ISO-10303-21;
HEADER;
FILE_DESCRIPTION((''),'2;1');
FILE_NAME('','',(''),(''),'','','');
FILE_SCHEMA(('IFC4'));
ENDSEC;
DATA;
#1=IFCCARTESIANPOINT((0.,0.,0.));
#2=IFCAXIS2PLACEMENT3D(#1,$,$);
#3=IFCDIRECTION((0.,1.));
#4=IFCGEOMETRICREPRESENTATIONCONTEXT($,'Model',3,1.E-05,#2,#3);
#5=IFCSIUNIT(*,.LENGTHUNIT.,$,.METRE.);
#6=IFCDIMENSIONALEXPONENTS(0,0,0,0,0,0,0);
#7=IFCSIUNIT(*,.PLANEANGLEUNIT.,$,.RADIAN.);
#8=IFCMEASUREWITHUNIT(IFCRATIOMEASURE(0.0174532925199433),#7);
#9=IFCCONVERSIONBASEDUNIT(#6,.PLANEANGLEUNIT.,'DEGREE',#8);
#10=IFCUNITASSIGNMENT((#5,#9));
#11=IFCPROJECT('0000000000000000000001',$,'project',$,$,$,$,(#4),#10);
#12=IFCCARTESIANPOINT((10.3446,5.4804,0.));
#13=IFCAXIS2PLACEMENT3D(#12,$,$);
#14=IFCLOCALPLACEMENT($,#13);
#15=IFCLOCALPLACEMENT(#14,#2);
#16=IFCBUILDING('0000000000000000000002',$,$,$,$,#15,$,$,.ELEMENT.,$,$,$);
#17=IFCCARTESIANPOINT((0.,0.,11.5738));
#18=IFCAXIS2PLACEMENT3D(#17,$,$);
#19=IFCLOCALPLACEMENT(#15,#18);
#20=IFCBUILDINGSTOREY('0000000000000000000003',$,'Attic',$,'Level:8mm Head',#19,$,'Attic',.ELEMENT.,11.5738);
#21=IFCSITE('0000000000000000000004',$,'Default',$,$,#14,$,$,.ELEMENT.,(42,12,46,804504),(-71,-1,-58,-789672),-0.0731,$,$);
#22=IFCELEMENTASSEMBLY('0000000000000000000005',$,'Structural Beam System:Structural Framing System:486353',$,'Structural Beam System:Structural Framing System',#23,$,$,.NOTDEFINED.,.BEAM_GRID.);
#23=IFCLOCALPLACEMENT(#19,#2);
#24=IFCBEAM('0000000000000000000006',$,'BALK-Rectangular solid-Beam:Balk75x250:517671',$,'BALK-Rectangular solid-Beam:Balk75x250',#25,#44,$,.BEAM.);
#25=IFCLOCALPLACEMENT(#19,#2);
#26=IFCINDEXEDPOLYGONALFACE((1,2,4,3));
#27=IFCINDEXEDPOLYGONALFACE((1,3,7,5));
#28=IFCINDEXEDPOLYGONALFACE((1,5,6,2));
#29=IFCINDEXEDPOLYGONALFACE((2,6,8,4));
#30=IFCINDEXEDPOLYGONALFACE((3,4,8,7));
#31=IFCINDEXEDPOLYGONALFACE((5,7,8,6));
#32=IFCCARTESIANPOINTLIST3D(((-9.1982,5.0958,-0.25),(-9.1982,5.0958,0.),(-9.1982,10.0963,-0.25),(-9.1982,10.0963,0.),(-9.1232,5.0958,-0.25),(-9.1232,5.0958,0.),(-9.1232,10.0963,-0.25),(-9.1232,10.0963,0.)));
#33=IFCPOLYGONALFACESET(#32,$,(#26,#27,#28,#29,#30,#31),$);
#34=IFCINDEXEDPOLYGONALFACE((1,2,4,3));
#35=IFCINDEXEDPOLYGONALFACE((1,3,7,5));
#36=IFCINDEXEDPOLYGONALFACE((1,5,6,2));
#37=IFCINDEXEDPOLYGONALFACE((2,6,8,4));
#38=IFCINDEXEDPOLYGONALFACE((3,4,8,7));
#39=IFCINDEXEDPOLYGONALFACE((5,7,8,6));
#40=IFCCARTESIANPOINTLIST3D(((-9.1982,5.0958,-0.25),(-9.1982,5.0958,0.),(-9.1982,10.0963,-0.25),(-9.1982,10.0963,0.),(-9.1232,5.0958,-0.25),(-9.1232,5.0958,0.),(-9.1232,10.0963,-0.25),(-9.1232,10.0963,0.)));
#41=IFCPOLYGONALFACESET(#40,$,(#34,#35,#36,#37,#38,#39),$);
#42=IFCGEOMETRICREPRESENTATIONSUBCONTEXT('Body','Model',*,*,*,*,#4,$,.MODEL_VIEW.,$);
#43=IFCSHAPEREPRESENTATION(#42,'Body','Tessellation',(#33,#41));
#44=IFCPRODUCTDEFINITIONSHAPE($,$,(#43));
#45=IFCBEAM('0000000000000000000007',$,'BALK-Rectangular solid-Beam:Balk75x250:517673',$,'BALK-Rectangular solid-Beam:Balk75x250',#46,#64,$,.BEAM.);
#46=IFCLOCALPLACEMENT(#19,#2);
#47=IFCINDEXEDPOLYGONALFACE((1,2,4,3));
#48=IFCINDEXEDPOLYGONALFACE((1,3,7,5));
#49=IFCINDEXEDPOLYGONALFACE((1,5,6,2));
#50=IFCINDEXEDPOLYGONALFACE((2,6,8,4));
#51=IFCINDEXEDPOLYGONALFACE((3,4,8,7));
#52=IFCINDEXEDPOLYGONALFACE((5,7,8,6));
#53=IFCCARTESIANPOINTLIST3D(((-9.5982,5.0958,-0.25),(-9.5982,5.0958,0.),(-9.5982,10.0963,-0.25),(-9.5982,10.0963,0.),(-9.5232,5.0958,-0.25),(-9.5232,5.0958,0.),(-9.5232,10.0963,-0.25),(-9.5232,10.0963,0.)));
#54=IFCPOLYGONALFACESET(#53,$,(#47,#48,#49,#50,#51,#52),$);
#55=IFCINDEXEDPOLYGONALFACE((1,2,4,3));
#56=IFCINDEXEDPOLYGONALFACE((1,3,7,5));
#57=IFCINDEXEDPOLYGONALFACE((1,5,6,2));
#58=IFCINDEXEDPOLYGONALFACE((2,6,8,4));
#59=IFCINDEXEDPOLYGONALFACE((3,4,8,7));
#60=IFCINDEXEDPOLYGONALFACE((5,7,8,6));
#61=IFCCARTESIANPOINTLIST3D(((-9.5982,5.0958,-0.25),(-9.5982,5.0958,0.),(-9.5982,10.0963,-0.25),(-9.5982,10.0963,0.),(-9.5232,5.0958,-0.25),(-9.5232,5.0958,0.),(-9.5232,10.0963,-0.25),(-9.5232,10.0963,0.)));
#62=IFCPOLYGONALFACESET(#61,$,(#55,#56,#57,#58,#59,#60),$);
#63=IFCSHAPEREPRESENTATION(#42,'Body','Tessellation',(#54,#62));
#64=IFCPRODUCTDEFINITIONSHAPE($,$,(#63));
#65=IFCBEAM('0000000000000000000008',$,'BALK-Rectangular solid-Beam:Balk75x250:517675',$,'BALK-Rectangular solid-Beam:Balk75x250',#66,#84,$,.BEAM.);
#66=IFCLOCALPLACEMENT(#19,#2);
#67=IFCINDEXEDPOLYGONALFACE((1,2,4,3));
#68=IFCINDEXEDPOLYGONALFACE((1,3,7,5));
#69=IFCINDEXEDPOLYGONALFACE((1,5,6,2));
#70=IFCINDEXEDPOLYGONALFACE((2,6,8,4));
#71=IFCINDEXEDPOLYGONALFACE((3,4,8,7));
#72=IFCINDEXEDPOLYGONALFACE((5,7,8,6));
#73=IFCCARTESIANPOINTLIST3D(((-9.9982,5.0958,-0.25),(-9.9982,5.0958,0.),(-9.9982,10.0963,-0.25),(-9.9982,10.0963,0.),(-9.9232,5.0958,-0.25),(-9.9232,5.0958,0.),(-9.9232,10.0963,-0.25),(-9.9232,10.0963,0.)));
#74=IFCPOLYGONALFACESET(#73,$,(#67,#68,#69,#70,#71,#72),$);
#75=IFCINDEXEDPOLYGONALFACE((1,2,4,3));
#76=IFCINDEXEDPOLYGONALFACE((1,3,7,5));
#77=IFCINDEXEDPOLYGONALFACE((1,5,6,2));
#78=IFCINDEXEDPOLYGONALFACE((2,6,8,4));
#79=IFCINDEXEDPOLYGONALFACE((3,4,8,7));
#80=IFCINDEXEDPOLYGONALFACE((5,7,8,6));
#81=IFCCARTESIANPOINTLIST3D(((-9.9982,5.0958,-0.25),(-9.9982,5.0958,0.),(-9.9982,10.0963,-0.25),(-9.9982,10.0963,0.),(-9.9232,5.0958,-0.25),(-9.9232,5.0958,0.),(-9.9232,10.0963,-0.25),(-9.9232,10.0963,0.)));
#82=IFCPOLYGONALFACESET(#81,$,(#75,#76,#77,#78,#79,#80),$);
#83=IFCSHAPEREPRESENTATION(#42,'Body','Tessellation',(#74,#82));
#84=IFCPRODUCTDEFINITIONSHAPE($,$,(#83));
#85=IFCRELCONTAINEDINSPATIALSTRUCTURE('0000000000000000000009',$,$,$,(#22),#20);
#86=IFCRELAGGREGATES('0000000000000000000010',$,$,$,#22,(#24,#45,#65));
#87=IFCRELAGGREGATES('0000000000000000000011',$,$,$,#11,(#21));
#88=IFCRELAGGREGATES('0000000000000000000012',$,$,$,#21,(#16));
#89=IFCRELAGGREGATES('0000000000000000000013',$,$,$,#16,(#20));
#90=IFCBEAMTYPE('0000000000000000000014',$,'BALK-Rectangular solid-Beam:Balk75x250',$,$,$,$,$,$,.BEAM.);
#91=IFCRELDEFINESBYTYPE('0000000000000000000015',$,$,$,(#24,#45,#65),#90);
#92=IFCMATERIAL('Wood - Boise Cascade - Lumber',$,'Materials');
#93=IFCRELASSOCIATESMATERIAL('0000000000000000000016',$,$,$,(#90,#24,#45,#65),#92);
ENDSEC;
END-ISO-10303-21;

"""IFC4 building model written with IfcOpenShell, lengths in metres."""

from ifc_helpers import new_model, entity, si_unit, converted_unit, direction, frame, frame_2d, origin, origin_2d_with_axis, place, context, subcontext, project, spatial, rectangle, extrude, source, transform, mapped, material, material_profile, profile_set, profile_usage, type_object, type_shapes, element, aggregate, save


model = new_model("IFC4")

# Units and contexts
model_context = context("Model", 3, precision=1e-05, world=origin(), true_north=direction((0.0, 1.0)))
body_context = subcontext(model_context, "Body", "Model", "MODEL_VIEW")
ifc_project = project(units=[si_unit("LENGTHUNIT", "METRE"), converted_unit("PLANEANGLEUNIT", "DEGREE", entity("IfcRatioMeasure", 0.0174532925199433), si_unit("PLANEANGLEUNIT", "RADIAN"), dimensions=[0, 0, 0, 0, 0, 0, 0])], contexts=[model_context])

# Site, building, storey
site_placement = place(None, frame((10.3446, 5.4804, 0.0)))
site = spatial("IfcSite", under=ifc_project, at=site_placement, Name="Default", CompositionType="ELEMENT", RefLatitude=(42, 12, 46, 804504), RefLongitude=(-71, -1, -58, -789672), RefElevation=-0.0731)
building_placement = place(site_placement, origin())
building = spatial("IfcBuilding", under=site, at=building_placement, CompositionType="ELEMENT")
storey_placement = place(building_placement, frame((0.0, 0.0, 11.5738)))
storey = spatial("IfcBuildingStorey", under=building, at=storey_placement, Name="Attic", ObjectType="Level:8mm Head", LongName="Attic", CompositionType="ELEMENT", Elevation=11.5738)

# Element assembly
assembly_1_placement = place(storey_placement, origin())
assembly_1 = element("IfcElementAssembly", 1, at=assembly_1_placement, inside=storey, Name="Structural Beam System:Structural Framing System:486353", ObjectType="Structural Beam System:Structural Framing System", AssemblyPlace="NOTDEFINED", PredefinedType="BEAM_GRID")
ifc_material = material(Name="Wood - Boise Cascade - Lumber", Category="Materials")
ifc_material_profile = material_profile(ifc_material, rectangle(XDim=0.25, YDim=0.075, at=frame_2d((0.0, 0.0), x_axis=(1.0, 0.0))), Name="Balk75x250")
ifc_profile_set = profile_set([ifc_material_profile], Name="Balk75x250")

# Beams
beam_type_1 = type_object("IfcBeamType", Name="BALK-Rectangular solid-Beam:Balk75x250", PredefinedType="BEAM", material=ifc_profile_set)
shared_shape_1 = source(origin(), body_context, "Body", "SweptSolid", [
    extrude(rectangle(XDim=0.25, YDim=0.075, at=origin_2d_with_axis()), frame((-2.394, 0.0, 0.0), z_axis=(1.0, 0.0, 0.0), x_axis=(0.0, 0.0, -1.0)), (0.0, 0.0, 1.0), 5.0005),
    extrude(rectangle(XDim=0.25, YDim=0.075, at=origin_2d_with_axis()), frame((-2.394, 0.0, 0.0), z_axis=(1.0, 0.0, 0.0), x_axis=(0.0, 0.0, -1.0)), (0.0, 0.0, 1.0), 5.0005),
])
type_shapes(beam_type_1, [shared_shape_1])
ifc_profile_usage_1 = profile_usage(ifc_profile_set, cardinal=8)
beam_1_placement = place(assembly_1_placement, frame((-9.1607, 7.7023, -0.125), z_axis=(0.0, 0.0, 1.0), x_axis=(0.0, -1.0, 0.0)))
beam_1 = element("IfcBeam", 2, at=beam_1_placement, type_object=beam_type_1, material=ifc_profile_usage_1, Name="BALK-Rectangular solid-Beam:Balk75x250:517671", ObjectType="BALK-Rectangular solid-Beam:Balk75x250", PredefinedType="BEAM", context=body_context, shape_type="MappedRepresentation", body=[
    mapped(shared_shape_1, transform((0.0, 0.0, 0.0), scale=1.0)),
])
ifc_profile_usage_2 = profile_usage(ifc_profile_set, cardinal=8)
beam_2_placement = place(assembly_1_placement, frame((-9.5607, 7.7023, -0.125), z_axis=(0.0, 0.0, 1.0), x_axis=(0.0, -1.0, 0.0)))
beam_2 = element("IfcBeam", 3, at=beam_2_placement, type_object=beam_type_1, material=ifc_profile_usage_2, Name="BALK-Rectangular solid-Beam:Balk75x250:517673", ObjectType="BALK-Rectangular solid-Beam:Balk75x250", PredefinedType="BEAM", context=body_context, shape_type="MappedRepresentation", body=[
    mapped(shared_shape_1, transform((0.0, 0.0, 0.0), scale=1.0)),
])
ifc_profile_usage_3 = profile_usage(ifc_profile_set, cardinal=8)
beam_3_placement = place(assembly_1_placement, frame((-9.9607, 7.7023, -0.125), z_axis=(0.0, 0.0, 1.0), x_axis=(0.0, -1.0, 0.0)))
beam_3 = element("IfcBeam", 4, at=beam_3_placement, type_object=beam_type_1, material=ifc_profile_usage_3, Name="BALK-Rectangular solid-Beam:Balk75x250:517675", ObjectType="BALK-Rectangular solid-Beam:Balk75x250", PredefinedType="BEAM", context=body_context, shape_type="MappedRepresentation", body=[
    mapped(shared_shape_1, transform((0.0, 0.0, 0.0), scale=1.0)),
])
aggregate(assembly_1, [beam_1, beam_2, beam_3])

save(model, "model.ifc")
